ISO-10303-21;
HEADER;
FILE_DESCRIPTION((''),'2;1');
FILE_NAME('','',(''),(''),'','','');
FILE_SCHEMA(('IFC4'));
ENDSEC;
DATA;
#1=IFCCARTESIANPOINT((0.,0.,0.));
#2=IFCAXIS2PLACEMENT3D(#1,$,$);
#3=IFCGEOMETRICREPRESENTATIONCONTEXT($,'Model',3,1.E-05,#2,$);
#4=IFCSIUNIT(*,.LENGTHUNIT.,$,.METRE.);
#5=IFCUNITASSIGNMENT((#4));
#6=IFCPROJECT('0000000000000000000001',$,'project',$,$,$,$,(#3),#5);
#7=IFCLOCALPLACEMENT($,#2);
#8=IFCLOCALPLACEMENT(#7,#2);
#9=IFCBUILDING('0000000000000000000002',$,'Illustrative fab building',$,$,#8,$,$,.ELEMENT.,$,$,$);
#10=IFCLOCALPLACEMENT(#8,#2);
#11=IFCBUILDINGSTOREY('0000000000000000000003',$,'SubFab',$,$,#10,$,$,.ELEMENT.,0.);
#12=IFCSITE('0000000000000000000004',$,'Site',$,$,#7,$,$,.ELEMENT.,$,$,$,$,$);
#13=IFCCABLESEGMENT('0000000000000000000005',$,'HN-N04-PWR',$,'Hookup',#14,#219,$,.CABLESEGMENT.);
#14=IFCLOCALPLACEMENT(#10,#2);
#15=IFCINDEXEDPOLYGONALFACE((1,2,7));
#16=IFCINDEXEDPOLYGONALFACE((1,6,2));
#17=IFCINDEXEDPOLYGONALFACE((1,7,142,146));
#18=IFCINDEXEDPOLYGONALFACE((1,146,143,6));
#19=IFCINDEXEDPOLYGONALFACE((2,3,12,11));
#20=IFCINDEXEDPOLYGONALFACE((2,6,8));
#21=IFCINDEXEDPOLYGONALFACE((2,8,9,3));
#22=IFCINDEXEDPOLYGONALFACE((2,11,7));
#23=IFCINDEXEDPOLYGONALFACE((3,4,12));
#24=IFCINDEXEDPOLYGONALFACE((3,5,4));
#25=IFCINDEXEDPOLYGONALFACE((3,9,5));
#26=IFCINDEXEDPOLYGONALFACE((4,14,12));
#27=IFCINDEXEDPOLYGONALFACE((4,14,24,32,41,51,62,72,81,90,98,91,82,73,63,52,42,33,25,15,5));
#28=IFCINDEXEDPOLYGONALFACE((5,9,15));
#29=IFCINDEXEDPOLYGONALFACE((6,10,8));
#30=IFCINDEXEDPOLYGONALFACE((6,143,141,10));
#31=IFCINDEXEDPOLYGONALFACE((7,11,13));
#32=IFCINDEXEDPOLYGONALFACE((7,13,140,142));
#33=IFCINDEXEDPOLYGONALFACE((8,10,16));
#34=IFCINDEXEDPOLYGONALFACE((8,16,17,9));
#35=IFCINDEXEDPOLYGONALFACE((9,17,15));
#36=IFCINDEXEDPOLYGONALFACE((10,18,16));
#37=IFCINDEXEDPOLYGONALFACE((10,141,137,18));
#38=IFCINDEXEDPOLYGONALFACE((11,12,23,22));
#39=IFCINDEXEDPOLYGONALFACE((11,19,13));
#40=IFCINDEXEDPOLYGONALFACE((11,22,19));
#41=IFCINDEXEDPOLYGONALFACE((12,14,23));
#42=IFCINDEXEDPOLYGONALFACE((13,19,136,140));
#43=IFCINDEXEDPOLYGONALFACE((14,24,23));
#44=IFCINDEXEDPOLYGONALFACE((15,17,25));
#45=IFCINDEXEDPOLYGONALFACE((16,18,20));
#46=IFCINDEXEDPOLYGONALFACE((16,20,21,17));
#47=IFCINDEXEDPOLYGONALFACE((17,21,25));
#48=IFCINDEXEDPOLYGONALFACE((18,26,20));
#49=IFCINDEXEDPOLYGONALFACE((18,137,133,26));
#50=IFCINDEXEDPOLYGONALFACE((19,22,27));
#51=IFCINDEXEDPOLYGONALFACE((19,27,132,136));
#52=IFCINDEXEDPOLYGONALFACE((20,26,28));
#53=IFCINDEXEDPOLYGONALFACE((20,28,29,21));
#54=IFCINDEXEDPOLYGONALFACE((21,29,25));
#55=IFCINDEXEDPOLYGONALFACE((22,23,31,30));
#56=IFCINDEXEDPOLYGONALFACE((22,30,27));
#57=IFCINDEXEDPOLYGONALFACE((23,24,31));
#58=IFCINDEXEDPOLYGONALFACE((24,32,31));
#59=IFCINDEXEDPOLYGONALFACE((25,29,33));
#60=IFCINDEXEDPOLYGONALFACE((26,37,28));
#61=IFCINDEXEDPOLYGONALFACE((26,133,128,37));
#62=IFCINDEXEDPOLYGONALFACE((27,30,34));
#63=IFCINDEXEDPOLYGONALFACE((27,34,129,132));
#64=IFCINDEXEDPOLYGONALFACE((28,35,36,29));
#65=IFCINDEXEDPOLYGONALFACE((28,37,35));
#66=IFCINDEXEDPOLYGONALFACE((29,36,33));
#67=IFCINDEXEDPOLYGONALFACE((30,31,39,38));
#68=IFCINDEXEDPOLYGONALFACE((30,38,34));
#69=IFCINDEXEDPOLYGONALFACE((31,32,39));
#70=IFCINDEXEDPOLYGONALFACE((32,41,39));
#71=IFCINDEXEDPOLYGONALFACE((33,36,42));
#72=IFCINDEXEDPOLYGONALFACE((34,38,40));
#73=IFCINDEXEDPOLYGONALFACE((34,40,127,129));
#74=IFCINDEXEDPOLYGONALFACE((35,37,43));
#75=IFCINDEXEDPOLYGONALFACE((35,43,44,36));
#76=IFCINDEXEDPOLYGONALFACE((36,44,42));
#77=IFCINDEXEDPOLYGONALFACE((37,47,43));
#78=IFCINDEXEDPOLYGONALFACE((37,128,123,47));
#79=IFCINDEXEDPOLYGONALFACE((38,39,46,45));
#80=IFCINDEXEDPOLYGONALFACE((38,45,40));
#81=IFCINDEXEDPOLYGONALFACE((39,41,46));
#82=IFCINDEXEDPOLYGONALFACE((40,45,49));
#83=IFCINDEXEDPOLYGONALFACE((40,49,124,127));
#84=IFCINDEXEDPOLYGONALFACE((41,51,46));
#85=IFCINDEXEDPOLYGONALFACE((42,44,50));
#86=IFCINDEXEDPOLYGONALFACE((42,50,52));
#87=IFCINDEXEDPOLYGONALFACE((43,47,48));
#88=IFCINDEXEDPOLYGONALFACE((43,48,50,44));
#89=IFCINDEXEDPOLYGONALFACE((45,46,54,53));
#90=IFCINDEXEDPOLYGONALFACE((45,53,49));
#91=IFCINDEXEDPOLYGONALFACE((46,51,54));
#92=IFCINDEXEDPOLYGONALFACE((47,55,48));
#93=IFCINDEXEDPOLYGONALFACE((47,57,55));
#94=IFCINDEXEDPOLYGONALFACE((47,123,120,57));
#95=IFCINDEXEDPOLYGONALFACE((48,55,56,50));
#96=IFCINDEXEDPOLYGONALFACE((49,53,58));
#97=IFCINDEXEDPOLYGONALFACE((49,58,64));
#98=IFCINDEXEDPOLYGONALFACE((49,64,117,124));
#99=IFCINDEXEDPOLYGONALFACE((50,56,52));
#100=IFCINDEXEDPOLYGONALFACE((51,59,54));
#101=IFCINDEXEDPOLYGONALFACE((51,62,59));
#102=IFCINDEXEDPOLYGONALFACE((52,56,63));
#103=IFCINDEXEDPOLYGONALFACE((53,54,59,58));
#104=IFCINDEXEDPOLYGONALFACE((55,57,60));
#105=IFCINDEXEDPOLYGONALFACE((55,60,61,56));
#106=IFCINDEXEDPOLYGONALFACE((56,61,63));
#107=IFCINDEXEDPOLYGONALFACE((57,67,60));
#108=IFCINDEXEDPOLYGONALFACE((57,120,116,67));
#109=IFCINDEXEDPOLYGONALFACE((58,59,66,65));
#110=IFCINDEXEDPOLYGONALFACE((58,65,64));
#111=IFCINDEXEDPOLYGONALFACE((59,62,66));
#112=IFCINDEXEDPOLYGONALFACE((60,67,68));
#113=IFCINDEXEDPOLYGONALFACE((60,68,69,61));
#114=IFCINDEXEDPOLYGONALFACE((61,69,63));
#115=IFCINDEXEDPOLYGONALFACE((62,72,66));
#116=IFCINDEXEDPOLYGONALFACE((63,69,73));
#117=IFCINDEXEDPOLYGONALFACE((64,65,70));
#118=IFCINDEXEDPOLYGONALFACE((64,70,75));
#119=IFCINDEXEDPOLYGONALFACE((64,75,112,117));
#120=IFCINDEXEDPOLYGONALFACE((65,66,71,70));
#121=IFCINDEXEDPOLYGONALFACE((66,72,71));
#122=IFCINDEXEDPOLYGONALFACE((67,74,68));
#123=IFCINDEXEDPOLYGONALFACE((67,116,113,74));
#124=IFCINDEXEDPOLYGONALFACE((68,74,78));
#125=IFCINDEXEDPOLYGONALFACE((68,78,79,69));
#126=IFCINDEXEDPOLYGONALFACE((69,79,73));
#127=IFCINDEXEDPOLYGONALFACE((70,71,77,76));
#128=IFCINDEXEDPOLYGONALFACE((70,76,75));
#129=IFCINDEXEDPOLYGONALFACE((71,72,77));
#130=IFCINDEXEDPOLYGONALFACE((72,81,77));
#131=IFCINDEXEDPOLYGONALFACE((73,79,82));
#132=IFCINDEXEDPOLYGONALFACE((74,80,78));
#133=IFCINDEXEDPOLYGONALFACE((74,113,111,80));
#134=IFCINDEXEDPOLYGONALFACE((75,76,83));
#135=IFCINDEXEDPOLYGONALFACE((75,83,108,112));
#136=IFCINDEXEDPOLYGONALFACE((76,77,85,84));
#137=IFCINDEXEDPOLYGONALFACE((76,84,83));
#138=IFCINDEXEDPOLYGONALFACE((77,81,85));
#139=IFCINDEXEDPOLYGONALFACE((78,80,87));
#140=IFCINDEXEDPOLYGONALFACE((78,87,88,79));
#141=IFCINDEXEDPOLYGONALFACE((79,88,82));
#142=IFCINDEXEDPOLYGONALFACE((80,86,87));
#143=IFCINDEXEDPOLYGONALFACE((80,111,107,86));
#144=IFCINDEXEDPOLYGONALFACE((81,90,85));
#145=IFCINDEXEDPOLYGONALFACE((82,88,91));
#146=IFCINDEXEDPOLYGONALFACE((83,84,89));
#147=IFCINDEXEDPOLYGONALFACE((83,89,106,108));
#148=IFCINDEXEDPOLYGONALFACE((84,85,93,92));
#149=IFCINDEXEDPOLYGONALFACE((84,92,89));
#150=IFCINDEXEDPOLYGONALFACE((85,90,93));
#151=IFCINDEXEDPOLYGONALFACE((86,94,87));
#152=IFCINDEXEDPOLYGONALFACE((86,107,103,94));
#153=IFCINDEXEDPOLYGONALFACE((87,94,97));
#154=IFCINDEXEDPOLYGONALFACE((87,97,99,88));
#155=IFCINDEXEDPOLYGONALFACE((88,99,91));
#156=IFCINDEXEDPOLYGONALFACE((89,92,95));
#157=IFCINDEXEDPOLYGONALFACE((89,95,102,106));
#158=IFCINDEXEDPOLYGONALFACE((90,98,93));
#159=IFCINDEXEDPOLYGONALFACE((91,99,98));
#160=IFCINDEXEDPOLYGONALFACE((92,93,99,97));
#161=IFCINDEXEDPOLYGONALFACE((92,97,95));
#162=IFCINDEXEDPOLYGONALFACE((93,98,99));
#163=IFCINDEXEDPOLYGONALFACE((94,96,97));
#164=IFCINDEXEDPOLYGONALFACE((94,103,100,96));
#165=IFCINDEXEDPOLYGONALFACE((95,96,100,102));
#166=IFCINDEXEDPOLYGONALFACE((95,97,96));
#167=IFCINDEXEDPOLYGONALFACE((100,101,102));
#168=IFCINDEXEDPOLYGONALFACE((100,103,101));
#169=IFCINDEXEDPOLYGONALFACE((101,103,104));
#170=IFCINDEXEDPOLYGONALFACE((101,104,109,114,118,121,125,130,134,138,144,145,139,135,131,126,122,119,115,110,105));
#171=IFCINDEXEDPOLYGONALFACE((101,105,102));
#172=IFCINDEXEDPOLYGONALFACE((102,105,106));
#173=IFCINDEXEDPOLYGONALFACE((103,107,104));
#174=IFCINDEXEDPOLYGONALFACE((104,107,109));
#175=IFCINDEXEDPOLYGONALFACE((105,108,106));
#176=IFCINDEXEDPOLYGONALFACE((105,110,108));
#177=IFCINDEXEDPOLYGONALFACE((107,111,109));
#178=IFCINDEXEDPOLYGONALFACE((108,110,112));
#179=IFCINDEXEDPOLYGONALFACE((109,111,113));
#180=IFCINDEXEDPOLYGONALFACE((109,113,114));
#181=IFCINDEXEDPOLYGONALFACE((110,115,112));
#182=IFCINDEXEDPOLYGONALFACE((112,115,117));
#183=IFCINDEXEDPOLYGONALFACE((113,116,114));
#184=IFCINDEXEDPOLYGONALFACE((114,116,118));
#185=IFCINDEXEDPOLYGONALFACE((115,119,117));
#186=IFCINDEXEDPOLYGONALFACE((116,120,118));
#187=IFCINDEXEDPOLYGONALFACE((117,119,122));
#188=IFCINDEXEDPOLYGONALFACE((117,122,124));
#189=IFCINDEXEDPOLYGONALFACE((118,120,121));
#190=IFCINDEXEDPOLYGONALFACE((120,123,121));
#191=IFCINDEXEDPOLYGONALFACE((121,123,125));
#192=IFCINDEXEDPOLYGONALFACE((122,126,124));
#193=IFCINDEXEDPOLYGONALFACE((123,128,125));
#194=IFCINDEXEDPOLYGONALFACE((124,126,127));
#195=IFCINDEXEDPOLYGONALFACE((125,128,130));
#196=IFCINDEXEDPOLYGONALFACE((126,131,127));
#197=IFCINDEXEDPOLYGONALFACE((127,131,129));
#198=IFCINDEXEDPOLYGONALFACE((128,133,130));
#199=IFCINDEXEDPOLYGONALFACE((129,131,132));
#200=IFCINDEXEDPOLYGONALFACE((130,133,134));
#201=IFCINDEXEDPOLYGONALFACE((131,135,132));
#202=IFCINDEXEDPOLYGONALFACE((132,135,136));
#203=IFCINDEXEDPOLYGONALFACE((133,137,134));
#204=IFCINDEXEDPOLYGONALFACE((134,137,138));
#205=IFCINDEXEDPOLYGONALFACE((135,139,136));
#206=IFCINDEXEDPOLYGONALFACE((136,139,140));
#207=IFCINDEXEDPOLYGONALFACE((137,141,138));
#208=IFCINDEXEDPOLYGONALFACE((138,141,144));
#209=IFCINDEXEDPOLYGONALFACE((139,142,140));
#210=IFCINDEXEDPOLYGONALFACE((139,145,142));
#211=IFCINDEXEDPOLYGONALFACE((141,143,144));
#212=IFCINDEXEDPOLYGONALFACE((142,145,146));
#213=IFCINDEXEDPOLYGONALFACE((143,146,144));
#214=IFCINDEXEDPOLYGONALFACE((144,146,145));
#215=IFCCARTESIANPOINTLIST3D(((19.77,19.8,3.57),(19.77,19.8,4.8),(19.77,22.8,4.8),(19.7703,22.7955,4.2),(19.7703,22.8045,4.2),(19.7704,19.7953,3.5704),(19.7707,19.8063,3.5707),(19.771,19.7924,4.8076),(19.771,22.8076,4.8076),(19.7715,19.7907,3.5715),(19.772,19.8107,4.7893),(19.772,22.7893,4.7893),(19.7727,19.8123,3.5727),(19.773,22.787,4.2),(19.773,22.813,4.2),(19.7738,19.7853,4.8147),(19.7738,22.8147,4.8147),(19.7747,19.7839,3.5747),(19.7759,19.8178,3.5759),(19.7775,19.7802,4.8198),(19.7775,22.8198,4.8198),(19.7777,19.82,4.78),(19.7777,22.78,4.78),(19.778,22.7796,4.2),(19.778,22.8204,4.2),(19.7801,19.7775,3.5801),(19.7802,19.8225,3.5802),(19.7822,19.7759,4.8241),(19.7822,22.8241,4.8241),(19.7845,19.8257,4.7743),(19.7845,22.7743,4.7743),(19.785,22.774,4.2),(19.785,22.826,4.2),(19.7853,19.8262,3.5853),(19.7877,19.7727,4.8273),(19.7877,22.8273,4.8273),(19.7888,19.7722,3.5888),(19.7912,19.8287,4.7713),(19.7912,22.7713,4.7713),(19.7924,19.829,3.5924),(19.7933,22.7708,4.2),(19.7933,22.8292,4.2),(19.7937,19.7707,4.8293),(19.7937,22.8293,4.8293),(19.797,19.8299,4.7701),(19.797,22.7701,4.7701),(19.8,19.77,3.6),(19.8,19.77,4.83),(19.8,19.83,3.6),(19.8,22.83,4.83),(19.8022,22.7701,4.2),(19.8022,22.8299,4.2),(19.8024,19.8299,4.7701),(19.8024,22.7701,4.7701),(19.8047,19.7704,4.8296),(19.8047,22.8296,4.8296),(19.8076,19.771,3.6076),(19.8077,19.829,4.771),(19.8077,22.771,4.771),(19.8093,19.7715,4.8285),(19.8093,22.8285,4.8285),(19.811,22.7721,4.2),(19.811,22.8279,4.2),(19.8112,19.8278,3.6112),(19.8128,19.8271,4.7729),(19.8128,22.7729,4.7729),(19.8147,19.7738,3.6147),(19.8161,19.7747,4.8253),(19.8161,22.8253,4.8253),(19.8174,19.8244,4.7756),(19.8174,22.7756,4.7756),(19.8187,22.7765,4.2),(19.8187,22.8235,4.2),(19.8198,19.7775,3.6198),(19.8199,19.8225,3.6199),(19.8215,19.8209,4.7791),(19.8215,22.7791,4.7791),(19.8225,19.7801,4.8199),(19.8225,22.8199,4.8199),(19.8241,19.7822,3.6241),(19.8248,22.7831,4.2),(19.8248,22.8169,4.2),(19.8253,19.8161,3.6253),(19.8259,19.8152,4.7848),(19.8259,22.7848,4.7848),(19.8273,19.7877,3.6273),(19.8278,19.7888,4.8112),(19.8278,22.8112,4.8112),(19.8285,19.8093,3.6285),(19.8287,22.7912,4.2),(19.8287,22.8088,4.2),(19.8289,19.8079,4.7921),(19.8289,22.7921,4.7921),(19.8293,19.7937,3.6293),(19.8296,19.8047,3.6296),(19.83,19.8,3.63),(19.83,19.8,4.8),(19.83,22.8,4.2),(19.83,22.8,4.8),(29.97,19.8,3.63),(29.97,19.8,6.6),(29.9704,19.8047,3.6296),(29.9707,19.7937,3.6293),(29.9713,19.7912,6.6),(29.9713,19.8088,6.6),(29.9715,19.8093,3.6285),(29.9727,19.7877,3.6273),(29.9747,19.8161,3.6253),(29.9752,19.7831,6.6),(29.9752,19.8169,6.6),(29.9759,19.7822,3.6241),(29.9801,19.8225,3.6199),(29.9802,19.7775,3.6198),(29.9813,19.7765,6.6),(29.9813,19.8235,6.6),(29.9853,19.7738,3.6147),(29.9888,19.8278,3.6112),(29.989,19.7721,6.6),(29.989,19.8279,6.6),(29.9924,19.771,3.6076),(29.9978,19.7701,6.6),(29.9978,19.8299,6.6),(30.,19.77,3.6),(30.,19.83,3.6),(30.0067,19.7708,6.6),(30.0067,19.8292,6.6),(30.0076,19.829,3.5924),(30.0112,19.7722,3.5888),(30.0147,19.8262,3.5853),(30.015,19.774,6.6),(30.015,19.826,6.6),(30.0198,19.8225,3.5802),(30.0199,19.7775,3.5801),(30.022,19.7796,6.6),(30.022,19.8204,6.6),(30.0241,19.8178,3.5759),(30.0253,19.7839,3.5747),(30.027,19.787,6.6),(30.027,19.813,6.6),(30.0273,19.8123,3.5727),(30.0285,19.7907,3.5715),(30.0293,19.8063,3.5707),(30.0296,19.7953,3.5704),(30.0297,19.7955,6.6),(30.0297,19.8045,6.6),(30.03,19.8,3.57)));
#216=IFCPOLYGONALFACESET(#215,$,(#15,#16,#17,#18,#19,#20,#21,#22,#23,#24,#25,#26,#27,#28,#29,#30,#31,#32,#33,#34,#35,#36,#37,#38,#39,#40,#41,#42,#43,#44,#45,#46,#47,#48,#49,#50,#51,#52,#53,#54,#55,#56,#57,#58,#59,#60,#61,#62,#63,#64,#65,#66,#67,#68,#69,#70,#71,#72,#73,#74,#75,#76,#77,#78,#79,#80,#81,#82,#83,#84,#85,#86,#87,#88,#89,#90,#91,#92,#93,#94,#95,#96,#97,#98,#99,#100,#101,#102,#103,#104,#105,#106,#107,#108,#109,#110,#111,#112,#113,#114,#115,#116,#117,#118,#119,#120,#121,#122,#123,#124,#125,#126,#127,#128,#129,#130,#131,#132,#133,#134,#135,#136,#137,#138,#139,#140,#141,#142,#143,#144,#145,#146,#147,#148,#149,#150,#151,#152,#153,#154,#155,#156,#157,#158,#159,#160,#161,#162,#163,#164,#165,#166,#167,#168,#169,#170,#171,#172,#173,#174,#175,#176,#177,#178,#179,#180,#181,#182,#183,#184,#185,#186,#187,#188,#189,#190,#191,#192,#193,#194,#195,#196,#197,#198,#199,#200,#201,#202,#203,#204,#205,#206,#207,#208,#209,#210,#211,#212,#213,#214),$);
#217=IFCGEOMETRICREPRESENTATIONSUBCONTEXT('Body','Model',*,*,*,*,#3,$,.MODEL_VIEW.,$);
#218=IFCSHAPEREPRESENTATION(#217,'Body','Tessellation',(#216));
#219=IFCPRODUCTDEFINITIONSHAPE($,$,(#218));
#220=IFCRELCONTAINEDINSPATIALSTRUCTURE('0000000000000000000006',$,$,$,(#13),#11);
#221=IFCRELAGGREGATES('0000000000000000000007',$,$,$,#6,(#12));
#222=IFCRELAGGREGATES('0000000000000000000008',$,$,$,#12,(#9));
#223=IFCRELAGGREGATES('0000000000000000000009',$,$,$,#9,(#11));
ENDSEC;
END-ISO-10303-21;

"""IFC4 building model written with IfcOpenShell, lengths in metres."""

from ifc_helpers import new_model, entity, si_unit, origin, place, context, subcontext, project, spatial, element, save


model = new_model("IFC4")

# Units and contexts
model_context = context("Model", 3, precision=1e-05, world=origin())
body_context = subcontext(model_context, "Body", "Model", "MODEL_VIEW")
ifc_project = project(units=[si_unit("LENGTHUNIT", "METRE")], contexts=[model_context])

# Site, building, storey
site_placement = place(None, origin())
site = spatial("IfcSite", under=ifc_project, at=site_placement, Name="Site", CompositionType="ELEMENT")
building_placement = place(site_placement, origin())
building = spatial("IfcBuilding", under=site, at=building_placement, Name="Illustrative fab building", CompositionType="ELEMENT")
storey_placement = place(building_placement, origin())
storey = spatial("IfcBuildingStorey", under=building, at=storey_placement, Name="SubFab", CompositionType="ELEMENT", Elevation=0.0)

# Cable segment
cable_segment_1_placement = place(storey_placement, origin())
element("IfcCableSegment", 1, at=cable_segment_1_placement, inside=storey, Name="HN-N04-PWR", ObjectType="Hookup", PredefinedType="CABLESEGMENT", context=body_context, shape_type="AdvancedSweptSolid", body=[
    entity("IfcSweptDiskSolid", entity("IfcPolyline", [entity("IfcCartesianPoint", [19.8, 22.8, 4.2]), entity("IfcCartesianPoint", [19.8, 22.8, 4.8]), entity("IfcCartesianPoint", [19.8, 19.8, 4.8]), entity("IfcCartesianPoint", [19.8, 19.8, 3.6]), entity("IfcCartesianPoint", [30.0, 19.8, 3.6]), entity("IfcCartesianPoint", [30.0, 19.8, 6.6])]), 0.03),
])

save(model, "model.ifc")
